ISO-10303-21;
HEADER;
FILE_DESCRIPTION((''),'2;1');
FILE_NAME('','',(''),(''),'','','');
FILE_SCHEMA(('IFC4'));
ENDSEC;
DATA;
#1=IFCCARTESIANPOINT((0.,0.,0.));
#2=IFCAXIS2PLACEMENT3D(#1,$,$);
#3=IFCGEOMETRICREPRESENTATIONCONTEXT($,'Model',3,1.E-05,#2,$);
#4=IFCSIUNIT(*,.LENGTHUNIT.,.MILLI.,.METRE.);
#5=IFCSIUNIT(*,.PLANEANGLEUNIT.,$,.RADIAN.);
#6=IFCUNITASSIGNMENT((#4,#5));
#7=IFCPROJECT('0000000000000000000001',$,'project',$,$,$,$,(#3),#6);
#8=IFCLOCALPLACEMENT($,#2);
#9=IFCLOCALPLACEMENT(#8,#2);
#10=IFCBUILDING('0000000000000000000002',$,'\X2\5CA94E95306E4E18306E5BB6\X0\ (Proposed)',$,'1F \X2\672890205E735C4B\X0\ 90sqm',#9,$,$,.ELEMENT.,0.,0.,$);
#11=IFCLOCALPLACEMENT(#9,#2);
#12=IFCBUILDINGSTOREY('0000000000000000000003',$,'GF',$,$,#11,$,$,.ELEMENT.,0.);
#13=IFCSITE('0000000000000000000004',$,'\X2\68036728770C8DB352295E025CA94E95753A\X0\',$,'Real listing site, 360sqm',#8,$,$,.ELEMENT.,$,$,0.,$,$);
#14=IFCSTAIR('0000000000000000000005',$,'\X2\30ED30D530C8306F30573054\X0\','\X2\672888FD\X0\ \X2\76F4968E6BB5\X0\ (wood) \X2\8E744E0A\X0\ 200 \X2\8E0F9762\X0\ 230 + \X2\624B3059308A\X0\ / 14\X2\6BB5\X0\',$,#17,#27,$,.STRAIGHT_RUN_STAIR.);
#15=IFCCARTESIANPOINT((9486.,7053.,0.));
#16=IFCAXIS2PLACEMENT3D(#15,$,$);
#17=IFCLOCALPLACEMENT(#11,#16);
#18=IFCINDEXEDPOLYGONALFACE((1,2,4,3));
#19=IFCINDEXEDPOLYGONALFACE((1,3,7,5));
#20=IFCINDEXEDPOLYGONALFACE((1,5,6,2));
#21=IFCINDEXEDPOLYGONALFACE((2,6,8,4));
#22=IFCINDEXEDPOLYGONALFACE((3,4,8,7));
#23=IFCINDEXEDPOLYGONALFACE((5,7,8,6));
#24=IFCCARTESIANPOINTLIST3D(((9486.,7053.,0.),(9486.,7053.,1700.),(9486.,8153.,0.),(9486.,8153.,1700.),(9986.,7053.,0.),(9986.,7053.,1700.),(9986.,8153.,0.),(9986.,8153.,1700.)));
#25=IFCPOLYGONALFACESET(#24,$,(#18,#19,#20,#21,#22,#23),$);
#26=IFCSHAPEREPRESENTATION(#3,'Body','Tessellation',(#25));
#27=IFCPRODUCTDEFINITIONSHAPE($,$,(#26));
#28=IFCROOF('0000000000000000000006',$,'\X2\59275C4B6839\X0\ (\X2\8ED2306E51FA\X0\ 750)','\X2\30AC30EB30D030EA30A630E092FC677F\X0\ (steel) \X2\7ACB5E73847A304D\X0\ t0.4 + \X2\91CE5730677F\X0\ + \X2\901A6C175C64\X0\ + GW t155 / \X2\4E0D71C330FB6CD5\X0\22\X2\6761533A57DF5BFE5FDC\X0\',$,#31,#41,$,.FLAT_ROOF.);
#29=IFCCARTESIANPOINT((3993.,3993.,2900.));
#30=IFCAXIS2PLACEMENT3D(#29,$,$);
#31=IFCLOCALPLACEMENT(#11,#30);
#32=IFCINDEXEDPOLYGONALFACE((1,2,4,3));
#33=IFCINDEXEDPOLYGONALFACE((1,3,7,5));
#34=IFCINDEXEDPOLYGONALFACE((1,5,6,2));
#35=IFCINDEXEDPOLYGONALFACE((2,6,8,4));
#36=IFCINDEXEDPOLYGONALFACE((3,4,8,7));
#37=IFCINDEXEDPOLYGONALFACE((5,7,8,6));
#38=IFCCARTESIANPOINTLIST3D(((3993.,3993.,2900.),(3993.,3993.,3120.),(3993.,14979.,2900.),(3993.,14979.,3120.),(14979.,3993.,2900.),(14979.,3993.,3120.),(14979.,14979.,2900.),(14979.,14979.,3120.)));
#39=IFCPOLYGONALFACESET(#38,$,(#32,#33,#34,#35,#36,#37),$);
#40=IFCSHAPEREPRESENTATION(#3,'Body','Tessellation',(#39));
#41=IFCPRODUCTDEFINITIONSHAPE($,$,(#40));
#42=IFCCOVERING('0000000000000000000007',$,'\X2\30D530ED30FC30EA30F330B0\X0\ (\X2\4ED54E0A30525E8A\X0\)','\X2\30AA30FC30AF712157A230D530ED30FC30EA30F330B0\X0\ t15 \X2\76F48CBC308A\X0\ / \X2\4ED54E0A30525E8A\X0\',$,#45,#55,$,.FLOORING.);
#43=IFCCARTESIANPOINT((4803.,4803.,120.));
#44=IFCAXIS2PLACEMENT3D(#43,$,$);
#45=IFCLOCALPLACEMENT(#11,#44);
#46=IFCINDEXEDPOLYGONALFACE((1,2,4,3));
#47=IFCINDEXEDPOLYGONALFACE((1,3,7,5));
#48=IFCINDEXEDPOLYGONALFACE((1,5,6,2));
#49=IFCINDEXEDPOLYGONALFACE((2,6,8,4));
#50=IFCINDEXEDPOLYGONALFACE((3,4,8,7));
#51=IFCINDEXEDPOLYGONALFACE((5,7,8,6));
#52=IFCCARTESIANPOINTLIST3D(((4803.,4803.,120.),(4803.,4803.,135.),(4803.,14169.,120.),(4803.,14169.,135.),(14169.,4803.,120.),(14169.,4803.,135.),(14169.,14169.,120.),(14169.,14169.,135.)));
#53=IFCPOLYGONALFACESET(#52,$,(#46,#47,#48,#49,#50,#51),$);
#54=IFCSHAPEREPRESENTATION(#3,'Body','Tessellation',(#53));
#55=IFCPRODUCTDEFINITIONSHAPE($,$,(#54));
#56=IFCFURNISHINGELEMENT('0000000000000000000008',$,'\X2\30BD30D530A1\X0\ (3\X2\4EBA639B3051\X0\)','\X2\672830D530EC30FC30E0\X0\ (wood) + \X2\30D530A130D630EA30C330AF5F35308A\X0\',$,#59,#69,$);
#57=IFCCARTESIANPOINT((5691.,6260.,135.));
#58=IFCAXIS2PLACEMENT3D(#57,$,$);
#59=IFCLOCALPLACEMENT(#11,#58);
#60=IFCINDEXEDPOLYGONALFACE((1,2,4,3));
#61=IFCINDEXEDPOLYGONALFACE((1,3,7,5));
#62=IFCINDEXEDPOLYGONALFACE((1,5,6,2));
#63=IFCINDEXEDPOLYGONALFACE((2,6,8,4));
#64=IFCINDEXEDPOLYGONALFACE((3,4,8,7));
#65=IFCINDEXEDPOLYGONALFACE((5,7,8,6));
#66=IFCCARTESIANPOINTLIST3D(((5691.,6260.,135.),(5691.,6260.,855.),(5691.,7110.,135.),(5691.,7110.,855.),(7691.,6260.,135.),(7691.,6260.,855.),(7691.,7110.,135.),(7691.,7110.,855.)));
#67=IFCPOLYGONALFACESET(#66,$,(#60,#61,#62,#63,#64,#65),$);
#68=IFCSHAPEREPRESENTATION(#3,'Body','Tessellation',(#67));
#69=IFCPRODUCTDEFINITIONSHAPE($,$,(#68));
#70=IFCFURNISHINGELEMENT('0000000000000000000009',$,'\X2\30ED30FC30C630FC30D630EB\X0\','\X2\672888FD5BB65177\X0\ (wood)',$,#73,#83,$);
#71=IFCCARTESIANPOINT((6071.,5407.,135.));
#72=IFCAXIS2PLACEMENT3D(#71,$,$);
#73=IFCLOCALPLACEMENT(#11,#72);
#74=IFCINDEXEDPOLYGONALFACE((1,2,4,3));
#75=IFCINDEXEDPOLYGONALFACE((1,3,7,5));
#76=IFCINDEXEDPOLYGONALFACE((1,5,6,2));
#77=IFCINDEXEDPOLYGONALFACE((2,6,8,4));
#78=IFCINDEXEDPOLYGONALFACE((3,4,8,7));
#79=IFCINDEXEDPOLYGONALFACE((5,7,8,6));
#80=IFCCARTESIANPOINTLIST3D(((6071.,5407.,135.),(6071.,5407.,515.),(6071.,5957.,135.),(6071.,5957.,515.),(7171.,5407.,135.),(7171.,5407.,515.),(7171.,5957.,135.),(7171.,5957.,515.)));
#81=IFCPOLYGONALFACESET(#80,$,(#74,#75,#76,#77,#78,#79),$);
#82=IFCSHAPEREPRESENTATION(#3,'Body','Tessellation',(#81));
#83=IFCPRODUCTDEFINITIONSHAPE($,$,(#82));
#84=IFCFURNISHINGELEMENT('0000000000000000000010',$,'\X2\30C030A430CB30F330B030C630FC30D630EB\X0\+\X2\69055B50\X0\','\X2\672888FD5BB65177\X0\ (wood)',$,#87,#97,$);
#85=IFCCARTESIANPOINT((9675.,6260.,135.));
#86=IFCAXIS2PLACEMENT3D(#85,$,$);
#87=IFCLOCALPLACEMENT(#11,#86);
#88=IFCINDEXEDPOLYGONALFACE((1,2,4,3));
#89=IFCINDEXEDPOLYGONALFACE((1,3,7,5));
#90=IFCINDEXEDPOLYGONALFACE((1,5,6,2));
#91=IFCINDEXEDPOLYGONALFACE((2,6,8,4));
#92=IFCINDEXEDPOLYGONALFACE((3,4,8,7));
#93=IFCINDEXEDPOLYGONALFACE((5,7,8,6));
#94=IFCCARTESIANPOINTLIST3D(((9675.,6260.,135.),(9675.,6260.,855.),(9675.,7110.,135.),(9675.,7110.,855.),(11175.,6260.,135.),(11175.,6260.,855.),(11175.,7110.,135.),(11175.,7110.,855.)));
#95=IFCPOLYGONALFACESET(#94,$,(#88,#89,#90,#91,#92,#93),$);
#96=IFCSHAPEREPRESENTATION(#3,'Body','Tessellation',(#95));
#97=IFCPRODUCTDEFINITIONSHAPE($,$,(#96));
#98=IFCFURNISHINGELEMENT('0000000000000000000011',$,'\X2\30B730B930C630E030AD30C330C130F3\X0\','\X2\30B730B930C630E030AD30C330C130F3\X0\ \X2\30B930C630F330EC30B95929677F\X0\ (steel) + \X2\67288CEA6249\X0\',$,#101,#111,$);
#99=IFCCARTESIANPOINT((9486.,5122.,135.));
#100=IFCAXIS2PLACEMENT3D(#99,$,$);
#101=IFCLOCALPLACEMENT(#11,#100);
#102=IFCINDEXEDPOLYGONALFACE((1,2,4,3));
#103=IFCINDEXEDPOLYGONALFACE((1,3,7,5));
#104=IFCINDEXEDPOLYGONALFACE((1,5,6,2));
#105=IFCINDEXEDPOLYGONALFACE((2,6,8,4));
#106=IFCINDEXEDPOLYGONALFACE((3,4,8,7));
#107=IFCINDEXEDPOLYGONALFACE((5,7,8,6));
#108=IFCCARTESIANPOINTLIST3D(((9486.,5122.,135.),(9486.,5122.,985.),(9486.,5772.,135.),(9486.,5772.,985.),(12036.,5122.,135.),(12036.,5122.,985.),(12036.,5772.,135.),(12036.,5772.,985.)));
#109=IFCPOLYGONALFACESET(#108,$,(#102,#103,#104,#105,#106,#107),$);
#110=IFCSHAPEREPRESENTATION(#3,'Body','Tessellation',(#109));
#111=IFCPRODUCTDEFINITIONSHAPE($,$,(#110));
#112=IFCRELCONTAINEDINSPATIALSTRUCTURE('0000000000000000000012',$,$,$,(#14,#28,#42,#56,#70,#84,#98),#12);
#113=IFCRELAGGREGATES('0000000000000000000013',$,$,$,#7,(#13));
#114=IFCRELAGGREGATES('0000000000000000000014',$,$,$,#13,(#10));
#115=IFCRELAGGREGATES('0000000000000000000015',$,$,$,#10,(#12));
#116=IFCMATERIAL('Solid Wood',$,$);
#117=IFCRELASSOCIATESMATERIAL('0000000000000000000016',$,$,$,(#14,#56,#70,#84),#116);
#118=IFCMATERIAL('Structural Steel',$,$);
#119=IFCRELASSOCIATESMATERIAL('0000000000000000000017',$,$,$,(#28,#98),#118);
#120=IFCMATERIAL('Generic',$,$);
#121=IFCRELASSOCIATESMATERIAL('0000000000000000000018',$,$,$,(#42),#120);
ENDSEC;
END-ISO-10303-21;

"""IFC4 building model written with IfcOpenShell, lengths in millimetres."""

from ifc_helpers import new_model, si_unit, frame, frame_2d, origin, place, context, project, spatial, rectangle, extrude, material, element, save


model = new_model("IFC4")

# Units and contexts
model_context = context("Model", 3, precision=1e-05, world=origin())
ifc_project = project(units=[si_unit("LENGTHUNIT", "METRE", prefix="MILLI"), si_unit("PLANEANGLEUNIT", "RADIAN")], contexts=[model_context])

# Site, building, storey
site_placement = place(None, origin())
site = spatial("IfcSite", under=ifc_project, at=site_placement, Name="栃木県足利市岩井町", ObjectType="Real listing site, 360sqm", CompositionType="ELEMENT", RefElevation=0.0)
building_placement = place(site_placement, origin())
building = spatial("IfcBuilding", under=site, at=building_placement, Name="岩井の丘の家 (Proposed)", ObjectType="1F 木造平屋 90sqm", CompositionType="ELEMENT", ElevationOfRefHeight=0.0, ElevationOfTerrain=0.0)
storey_placement = place(building_placement, origin())
storey = spatial("IfcBuildingStorey", under=building, at=storey_placement, Name="GF", CompositionType="ELEMENT", Elevation=0.0)

# Shared definitions
ifc_material_1 = material(Name="Solid Wood")

# Stair
stair_placement = place(storey_placement, frame((9486.0, 7053.0, 0.0)))
element("IfcStair", 1, at=stair_placement, inside=storey, material=ifc_material_1, Name="ロフトはしご", Description="木製 直階段 (wood) 蹴上 200 踏面 230 + 手すり / 14段", PredefinedType="STRAIGHT_RUN_STAIR", context=model_context, shape_type="SweptSolid", body=[
    extrude(rectangle(XDim=500.0, YDim=1100.0, at=frame_2d((250.0, 550.0))), frame((9486.0, 7053.0, 0.0)), (0.0, 0.0, 1.0), 1700.0),
])

# Roof
ifc_material_2 = material(Name="Structural Steel")
roof_placement = place(storey_placement, frame((3993.0, 3993.0, 2900.0)))
element("IfcRoof", 2, at=roof_placement, inside=storey, material=ifc_material_2, Name="大屋根 (軒の出 750)", Description="ガルバリウム鋼板 (steel) 立平葺き t0.4 + 野地板 + 通気層 + GW t155 / 不燃・法22条区域対応", PredefinedType="FLAT_ROOF", context=model_context, shape_type="SweptSolid", body=[
    extrude(rectangle(XDim=10986.0, YDim=10986.0, at=frame_2d((5493.0, 5493.0))), frame((3993.0, 3993.0, 2900.0)), (0.0, 0.0, 1.0), 220.0),
])

# Covering
ifc_material_3 = material(Name="Generic")
covering_placement = place(storey_placement, frame((4803.0, 4803.0, 120.0)))
element("IfcCovering", 3, at=covering_placement, inside=storey, material=ifc_material_3, Name="フローリング (仕上げ床)", Description="オーク無垢フローリング t15 直貼り / 仕上げ床", PredefinedType="FLOORING", context=model_context, shape_type="SweptSolid", body=[
    extrude(rectangle(XDim=9366.0, YDim=9366.0, at=frame_2d((4683.0, 4683.0))), frame((4803.0, 4803.0, 120.0)), (0.0, 0.0, 1.0), 15.0),
])

# Furnishing elements
furnishing_1_placement = place(storey_placement, frame((5691.0, 6260.0, 135.0)))
element("IfcFurnishingElement", 4, at=furnishing_1_placement, inside=storey, material=ifc_material_1, Name="ソファ (3人掛け)", Description="木フレーム (wood) + ファブリック張り", context=model_context, shape_type="SweptSolid", body=[
    extrude(rectangle(XDim=2000.0, YDim=850.0, at=frame_2d((1000.0, 425.0))), frame((5691.0, 6260.0, 135.0)), (0.0, 0.0, 1.0), 720.0),
])
furnishing_2_placement = place(storey_placement, frame((6071.0, 5407.0, 135.0)))
element("IfcFurnishingElement", 5, at=furnishing_2_placement, inside=storey, material=ifc_material_1, Name="ローテーブル", Description="木製家具 (wood)", context=model_context, shape_type="SweptSolid", body=[
    extrude(rectangle(XDim=1100.0, YDim=550.0, at=frame_2d((550.0, 275.0))), frame((6071.0, 5407.0, 135.0)), (0.0, 0.0, 1.0), 380.0),
])
furnishing_3_placement = place(storey_placement, frame((9675.0, 6260.0, 135.0)))
element("IfcFurnishingElement", 6, at=furnishing_3_placement, inside=storey, material=ifc_material_1, Name="ダイニングテーブル+椅子", Description="木製家具 (wood)", context=model_context, shape_type="SweptSolid", body=[
    extrude(rectangle(XDim=1500.0, YDim=850.0, at=frame_2d((750.0, 425.0))), frame((9675.0, 6260.0, 135.0)), (0.0, 0.0, 1.0), 720.0),
])
furnishing_4_placement = place(storey_placement, frame((9486.0, 5122.0, 135.0)))
element("IfcFurnishingElement", 7, at=furnishing_4_placement, inside=storey, material=ifc_material_2, Name="システムキッチン", Description="システムキッチン ステンレス天板 (steel) + 木質扉", context=model_context, shape_type="SweptSolid", body=[
    extrude(rectangle(XDim=2550.0, YDim=650.0, at=frame_2d((1275.0, 325.0))), frame((9486.0, 5122.0, 135.0)), (0.0, 0.0, 1.0), 850.0),
])

save(model, "model.ifc")
